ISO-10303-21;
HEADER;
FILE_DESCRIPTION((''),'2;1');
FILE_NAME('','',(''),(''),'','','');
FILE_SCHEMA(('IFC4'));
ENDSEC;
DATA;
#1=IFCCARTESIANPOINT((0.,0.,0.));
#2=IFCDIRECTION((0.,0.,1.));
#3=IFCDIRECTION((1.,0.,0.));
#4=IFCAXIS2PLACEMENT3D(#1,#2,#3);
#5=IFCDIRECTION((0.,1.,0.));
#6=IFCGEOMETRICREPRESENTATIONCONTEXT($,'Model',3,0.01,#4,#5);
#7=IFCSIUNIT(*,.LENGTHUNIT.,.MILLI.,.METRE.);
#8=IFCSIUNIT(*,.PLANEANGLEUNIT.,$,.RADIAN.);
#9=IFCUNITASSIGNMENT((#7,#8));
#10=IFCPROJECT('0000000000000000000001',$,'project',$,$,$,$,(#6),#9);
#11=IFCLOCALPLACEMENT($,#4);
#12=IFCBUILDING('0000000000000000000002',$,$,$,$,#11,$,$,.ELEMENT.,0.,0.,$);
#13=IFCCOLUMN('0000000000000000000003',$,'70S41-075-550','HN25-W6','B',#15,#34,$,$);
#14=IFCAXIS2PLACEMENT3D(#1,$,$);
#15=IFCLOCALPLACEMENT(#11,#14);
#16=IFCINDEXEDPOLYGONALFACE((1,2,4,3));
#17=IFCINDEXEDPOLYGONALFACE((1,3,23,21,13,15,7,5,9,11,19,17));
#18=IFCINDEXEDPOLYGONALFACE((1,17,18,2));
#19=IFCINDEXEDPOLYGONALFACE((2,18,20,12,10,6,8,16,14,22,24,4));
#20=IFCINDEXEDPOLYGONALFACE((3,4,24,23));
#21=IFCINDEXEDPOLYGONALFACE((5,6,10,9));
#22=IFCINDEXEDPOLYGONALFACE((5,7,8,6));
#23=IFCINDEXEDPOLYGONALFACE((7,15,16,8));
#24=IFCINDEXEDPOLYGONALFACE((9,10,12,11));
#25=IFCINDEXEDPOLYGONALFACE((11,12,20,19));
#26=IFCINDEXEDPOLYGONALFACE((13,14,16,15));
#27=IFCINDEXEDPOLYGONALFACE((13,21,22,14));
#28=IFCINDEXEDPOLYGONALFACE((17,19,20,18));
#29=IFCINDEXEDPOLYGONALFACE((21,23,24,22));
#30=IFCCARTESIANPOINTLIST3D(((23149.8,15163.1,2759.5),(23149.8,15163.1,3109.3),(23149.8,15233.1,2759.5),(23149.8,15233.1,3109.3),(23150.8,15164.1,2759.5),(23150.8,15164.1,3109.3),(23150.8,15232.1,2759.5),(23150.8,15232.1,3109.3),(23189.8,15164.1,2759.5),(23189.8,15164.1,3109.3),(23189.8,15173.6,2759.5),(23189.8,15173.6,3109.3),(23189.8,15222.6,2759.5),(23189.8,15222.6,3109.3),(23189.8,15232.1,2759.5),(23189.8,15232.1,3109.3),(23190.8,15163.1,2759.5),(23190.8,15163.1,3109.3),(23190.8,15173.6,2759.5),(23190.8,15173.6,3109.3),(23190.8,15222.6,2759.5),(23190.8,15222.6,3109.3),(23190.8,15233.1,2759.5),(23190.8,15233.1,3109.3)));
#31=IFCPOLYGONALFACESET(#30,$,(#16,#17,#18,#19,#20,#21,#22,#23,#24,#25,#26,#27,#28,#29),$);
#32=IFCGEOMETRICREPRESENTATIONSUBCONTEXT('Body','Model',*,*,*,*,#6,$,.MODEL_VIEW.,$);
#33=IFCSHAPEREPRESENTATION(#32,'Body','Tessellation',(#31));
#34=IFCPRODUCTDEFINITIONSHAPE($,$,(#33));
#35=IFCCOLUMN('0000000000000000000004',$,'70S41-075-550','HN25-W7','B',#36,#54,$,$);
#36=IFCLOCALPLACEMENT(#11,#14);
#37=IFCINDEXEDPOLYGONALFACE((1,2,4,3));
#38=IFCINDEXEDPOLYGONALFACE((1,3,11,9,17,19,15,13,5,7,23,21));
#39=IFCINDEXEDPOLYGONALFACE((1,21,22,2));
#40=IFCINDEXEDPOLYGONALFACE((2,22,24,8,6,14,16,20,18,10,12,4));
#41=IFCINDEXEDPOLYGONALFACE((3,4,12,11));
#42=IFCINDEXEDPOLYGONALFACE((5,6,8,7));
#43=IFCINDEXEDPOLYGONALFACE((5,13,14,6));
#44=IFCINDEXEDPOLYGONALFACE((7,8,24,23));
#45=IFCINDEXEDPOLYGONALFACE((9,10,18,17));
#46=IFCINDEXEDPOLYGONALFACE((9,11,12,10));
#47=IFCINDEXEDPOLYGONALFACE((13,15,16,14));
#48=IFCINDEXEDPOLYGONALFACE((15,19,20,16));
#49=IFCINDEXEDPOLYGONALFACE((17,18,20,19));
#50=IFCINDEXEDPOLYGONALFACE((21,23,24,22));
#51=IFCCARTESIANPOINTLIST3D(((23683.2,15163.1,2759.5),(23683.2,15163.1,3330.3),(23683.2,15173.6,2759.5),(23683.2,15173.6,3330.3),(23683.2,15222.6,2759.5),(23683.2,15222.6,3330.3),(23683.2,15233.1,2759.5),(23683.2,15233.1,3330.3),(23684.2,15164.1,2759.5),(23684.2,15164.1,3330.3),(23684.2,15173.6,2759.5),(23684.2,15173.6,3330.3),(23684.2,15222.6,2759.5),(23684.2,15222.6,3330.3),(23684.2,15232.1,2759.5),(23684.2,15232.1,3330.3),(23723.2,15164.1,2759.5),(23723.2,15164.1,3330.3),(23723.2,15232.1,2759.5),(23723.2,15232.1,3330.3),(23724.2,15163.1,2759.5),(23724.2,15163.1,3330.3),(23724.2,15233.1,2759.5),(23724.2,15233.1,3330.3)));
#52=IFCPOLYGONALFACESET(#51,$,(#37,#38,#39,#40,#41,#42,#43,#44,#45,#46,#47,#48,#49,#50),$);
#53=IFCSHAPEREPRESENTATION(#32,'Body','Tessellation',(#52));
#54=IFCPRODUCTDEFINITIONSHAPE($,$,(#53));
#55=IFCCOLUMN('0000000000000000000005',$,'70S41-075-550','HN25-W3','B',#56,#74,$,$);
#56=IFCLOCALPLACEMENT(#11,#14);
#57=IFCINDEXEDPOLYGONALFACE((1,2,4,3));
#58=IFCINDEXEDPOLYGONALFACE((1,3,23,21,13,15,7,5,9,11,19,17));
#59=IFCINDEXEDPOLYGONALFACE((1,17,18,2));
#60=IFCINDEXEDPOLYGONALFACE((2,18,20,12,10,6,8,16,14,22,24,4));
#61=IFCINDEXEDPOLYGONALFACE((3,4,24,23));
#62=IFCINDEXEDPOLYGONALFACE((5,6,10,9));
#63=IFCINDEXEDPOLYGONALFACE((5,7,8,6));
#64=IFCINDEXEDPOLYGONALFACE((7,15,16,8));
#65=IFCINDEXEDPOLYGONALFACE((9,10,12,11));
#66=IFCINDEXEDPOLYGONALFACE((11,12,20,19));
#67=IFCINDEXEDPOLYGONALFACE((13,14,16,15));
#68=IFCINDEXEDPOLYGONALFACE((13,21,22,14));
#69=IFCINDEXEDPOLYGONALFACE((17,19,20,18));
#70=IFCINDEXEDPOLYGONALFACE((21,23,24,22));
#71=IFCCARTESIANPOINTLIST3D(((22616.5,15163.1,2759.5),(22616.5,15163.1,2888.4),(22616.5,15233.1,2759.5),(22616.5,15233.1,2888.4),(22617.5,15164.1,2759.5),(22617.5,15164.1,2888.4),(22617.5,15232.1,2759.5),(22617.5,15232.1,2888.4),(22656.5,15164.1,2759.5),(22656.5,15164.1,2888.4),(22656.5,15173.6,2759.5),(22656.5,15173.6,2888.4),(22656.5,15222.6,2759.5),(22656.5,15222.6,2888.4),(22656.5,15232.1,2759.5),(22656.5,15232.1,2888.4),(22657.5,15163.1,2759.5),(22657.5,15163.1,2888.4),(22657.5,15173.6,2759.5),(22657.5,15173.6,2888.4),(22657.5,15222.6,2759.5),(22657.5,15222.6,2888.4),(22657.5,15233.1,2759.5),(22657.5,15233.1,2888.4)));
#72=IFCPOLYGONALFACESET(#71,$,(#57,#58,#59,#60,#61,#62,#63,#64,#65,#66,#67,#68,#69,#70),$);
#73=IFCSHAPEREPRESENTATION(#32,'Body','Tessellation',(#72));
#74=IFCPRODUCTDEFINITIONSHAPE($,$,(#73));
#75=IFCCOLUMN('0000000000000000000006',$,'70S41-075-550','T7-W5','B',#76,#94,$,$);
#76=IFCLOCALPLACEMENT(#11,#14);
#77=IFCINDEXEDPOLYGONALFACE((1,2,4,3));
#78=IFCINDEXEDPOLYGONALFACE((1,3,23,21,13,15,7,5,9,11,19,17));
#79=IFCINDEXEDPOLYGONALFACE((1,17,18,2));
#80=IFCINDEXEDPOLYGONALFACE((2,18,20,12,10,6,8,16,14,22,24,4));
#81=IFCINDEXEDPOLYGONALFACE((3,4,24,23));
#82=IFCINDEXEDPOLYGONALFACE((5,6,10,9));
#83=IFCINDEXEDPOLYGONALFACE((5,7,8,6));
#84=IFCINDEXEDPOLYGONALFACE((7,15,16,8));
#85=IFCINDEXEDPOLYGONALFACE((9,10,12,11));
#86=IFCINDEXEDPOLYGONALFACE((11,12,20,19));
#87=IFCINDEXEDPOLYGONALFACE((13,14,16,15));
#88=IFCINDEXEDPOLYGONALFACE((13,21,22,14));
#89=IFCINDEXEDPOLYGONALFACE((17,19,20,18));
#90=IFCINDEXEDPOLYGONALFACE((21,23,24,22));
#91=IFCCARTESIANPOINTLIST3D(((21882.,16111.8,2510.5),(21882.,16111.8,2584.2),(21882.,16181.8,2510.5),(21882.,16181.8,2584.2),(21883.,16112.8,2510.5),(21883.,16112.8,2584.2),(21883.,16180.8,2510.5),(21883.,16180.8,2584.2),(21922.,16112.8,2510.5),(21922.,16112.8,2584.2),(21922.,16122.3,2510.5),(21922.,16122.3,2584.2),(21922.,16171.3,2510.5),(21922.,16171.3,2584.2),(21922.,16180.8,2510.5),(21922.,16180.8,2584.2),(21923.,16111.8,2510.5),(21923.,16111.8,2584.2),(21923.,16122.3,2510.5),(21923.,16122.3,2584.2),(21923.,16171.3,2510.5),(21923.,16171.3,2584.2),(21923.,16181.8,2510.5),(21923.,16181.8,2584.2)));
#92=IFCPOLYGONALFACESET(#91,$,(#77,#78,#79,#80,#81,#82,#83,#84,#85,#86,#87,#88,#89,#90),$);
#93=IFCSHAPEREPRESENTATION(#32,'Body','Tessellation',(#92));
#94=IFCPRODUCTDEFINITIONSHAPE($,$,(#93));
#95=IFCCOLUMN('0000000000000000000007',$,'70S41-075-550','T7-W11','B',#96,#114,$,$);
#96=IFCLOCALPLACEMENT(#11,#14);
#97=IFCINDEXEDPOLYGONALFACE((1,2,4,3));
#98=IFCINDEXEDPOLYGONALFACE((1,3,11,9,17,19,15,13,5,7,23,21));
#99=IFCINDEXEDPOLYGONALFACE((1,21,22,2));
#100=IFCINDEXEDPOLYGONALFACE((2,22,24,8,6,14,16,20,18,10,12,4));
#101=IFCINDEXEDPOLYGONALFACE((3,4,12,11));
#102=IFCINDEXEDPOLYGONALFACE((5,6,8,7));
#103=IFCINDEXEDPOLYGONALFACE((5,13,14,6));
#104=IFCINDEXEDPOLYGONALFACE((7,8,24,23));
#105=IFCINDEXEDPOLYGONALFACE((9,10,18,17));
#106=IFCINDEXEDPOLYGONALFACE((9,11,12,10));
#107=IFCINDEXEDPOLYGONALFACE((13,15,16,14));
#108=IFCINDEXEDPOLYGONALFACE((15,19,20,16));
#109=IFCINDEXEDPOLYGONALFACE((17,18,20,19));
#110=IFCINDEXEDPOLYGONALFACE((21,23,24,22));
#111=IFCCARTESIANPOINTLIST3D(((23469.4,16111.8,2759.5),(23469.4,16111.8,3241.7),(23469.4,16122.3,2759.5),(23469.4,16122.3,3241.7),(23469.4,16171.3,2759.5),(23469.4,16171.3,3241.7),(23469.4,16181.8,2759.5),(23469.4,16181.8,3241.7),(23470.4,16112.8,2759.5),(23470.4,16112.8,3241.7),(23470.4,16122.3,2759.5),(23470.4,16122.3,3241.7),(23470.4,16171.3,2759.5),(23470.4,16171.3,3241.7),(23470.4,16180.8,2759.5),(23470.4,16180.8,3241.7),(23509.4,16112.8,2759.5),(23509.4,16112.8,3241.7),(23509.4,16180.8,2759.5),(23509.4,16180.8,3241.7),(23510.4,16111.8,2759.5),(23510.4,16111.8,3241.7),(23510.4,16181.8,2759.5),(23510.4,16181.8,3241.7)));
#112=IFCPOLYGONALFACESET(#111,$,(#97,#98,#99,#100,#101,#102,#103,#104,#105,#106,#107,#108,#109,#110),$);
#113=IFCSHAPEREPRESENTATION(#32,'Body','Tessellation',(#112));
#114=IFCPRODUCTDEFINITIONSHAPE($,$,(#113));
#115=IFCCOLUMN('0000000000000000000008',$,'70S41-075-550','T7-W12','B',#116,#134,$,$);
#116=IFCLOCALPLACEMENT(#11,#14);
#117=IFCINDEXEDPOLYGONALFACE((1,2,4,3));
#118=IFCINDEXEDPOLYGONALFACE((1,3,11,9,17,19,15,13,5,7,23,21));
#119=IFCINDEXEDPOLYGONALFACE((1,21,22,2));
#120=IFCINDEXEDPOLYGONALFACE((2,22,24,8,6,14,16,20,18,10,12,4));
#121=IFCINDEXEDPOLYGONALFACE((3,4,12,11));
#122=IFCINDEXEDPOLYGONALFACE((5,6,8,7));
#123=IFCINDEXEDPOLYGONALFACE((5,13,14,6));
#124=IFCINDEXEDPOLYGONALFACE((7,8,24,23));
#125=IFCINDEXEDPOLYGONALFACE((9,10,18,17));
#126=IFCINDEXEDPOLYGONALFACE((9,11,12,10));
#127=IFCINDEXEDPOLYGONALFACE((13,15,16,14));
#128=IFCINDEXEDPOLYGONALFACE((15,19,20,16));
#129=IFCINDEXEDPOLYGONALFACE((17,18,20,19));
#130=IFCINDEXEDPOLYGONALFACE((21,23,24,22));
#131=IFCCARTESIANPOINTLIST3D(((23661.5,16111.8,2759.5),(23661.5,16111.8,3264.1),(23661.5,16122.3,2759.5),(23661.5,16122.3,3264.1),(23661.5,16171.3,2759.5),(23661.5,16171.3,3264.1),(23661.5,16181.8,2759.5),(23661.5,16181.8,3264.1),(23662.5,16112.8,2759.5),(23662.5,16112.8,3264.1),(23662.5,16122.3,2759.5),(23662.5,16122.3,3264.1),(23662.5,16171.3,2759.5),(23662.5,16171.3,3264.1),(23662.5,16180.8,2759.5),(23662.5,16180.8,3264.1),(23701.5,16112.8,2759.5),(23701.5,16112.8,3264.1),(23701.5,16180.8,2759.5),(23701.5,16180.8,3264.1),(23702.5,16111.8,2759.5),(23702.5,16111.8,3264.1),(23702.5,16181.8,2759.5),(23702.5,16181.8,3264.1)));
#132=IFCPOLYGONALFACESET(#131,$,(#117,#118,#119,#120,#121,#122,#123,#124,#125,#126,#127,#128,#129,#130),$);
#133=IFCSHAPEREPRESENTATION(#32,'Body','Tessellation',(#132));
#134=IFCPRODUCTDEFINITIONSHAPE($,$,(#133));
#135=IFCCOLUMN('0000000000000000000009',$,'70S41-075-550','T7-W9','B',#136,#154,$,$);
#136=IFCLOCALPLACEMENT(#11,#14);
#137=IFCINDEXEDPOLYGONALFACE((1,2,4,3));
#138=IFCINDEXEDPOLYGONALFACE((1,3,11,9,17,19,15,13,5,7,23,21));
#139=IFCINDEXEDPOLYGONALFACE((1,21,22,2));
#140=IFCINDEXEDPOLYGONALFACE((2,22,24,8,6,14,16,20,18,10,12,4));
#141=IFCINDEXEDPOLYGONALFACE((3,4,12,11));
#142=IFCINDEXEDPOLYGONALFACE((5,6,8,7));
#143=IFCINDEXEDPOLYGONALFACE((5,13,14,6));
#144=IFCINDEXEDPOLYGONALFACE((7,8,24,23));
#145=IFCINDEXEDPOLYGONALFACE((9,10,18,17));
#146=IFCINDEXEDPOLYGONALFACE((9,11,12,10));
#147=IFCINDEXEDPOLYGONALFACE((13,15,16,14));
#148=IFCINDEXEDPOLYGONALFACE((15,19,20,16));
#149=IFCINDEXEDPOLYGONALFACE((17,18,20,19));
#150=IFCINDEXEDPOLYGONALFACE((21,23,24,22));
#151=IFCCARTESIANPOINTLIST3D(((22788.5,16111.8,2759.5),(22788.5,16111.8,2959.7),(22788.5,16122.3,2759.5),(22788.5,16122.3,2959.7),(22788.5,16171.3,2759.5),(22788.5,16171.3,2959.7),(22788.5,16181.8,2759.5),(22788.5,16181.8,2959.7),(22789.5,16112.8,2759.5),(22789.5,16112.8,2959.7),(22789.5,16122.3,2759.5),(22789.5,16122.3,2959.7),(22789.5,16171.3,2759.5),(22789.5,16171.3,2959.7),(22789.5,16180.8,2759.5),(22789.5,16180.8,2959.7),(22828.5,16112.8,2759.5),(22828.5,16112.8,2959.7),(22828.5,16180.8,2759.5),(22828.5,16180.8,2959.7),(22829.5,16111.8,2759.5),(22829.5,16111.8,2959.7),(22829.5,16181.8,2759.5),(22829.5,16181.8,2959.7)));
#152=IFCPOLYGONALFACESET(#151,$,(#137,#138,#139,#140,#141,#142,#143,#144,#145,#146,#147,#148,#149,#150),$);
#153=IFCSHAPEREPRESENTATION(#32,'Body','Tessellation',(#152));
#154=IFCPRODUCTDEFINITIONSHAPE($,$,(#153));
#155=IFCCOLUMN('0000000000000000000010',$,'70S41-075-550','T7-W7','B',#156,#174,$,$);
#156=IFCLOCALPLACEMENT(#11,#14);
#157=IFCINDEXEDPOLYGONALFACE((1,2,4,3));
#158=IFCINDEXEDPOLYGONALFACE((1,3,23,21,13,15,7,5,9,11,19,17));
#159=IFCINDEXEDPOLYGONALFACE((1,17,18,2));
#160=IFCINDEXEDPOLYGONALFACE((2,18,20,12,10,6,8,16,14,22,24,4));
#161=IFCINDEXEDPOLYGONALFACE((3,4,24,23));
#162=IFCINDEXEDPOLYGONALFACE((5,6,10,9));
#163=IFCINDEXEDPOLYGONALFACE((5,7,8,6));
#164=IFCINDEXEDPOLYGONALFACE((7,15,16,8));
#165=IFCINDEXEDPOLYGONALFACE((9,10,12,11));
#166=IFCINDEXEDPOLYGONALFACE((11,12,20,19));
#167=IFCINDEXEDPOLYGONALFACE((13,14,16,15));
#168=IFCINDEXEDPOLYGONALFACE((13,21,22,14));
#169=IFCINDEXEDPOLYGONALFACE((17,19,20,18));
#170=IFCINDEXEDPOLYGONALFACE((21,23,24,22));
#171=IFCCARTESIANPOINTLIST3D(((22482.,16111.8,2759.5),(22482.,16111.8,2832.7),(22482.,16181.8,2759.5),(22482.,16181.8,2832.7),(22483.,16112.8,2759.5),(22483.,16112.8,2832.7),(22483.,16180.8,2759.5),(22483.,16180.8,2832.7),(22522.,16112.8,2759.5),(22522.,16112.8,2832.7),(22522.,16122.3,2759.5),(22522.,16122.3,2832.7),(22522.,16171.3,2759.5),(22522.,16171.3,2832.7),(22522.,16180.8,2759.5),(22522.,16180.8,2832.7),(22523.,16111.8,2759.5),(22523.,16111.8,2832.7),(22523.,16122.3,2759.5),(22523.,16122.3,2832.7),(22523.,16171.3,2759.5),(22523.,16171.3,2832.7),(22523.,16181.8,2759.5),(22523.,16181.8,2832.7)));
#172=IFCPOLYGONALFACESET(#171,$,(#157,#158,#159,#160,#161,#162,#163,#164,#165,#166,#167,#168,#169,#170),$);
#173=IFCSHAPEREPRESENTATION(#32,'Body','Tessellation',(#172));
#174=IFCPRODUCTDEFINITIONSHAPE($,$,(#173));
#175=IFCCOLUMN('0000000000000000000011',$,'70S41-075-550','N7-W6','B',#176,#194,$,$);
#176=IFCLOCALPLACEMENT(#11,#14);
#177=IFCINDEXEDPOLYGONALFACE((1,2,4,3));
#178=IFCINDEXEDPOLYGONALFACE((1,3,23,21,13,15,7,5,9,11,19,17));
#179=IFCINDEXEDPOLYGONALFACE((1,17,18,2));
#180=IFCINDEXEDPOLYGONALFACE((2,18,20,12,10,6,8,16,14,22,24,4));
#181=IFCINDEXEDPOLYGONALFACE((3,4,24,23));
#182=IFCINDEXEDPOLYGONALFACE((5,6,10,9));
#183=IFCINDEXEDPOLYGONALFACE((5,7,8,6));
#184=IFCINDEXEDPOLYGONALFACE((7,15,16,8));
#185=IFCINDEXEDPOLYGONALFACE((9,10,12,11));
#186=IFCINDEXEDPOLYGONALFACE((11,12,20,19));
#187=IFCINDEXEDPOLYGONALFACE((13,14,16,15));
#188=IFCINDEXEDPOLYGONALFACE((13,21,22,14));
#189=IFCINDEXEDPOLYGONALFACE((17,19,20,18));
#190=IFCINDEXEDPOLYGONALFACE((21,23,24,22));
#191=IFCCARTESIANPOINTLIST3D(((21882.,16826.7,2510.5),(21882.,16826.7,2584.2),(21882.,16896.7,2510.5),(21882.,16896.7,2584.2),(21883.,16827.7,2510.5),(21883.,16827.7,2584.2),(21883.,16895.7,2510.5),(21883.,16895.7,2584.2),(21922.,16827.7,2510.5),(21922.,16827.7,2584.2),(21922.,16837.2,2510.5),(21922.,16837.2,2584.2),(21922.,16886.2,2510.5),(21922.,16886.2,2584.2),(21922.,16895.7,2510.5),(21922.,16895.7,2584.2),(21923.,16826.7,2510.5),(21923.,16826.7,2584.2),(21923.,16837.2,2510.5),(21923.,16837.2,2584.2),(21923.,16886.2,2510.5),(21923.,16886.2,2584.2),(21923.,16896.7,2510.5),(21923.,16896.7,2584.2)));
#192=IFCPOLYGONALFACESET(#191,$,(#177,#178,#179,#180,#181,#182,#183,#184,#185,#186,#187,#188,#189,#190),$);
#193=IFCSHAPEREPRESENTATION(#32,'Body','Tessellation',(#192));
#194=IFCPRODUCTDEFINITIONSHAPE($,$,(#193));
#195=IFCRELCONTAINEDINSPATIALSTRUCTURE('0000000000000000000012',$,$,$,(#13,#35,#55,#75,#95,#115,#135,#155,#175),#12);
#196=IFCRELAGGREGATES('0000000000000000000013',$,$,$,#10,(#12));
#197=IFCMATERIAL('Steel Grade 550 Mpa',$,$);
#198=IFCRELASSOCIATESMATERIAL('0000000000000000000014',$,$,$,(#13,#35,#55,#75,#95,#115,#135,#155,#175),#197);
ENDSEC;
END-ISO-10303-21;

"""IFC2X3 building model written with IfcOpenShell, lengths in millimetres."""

from ifc_helpers import new_model, si_unit, direction, frame, origin, origin_with_axes, origin_2d_with_axis, place, context, subcontext, project, spatial, c_section, extrude, source, transform, mapped, material, element, save


model = new_model("IFC2X3")

# Units and contexts
model_context = context("Model", 3, precision=0.01, world=origin_with_axes(), true_north=direction((0.0, 1.0, 0.0)))
body_context = subcontext(model_context, "Body", "Model", "MODEL_VIEW")
ifc_project = project(units=[si_unit("LENGTHUNIT", "METRE", prefix="MILLI"), si_unit("PLANEANGLEUNIT", "RADIAN")], contexts=[model_context])

# Building
building_placement = place(None, origin_with_axes())
building = spatial("IfcBuilding", under=ifc_project, at=building_placement, CompositionType="ELEMENT", ElevationOfRefHeight=0.0, ElevationOfTerrain=0.0)

# Columns
ifc_material = material(Name="Steel Grade 550 Mpa")
shared_shape_1 = source(origin(), body_context, "Body", "SweptSolid", [
    extrude(c_section(Depth=70.0, Width=41.0, WallThickness=1.0, Girth=10.5, at=origin_2d_with_axis()), origin_with_axes(), (0.0, 0.0, 1.0), 349.8),
])
column_1_placement = place(None, frame((23170.3, 15198.1, 3109.3), z_axis=(0.0, 0.0, -1.0), x_axis=(1.0, 0.0, 0.0)))
element("IfcColumn", 1, at=column_1_placement, inside=building, material=ifc_material, Name="70S41-075-550", Description="HN25-W6", ObjectType="B", context=body_context, shape_type="MappedRepresentation", body=[
    mapped(shared_shape_1, transform((0.0, 0.0, 0.0), scale=1.0)),
])
shared_shape_2 = source(origin(), body_context, "Body", "SweptSolid", [
    extrude(c_section(Depth=70.0, Width=41.0, WallThickness=1.0, Girth=10.5, at=origin_2d_with_axis()), origin_with_axes(), (0.0, 0.0, 1.0), 570.8),
])
column_2_placement = place(None, frame((23703.7, 15198.1, 2759.5), z_axis=(0.0, 0.0, 1.0), x_axis=(-1.0, 0.0, 0.0)))
element("IfcColumn", 2, at=column_2_placement, inside=building, material=ifc_material, Name="70S41-075-550", Description="HN25-W7", ObjectType="B", context=body_context, shape_type="MappedRepresentation", body=[
    mapped(shared_shape_2, transform((0.0, 0.0, 0.0), scale=1.0)),
])
shared_shape_3 = source(origin(), body_context, "Body", "SweptSolid", [
    extrude(c_section(Depth=70.0, Width=41.0, WallThickness=1.0, Girth=10.5, at=origin_2d_with_axis()), origin_with_axes(), (0.0, 0.0, 1.0), 128.9),
])
column_3_placement = place(None, frame((22637.0, 15198.1, 2888.4), z_axis=(0.0, 0.0, -1.0), x_axis=(1.0, 0.0, 0.0)))
element("IfcColumn", 3, at=column_3_placement, inside=building, material=ifc_material, Name="70S41-075-550", Description="HN25-W3", ObjectType="B", context=body_context, shape_type="MappedRepresentation", body=[
    mapped(shared_shape_3, transform((0.0, 0.0, 0.0), scale=1.0)),
])
shared_shape_4 = source(origin(), body_context, "Body", "SweptSolid", [
    extrude(c_section(Depth=70.0, Width=41.0, WallThickness=1.0, Girth=10.5, at=origin_2d_with_axis()), origin_with_axes(), (0.0, 0.0, 1.0), 73.7),
])
column_4_placement = place(None, frame((21902.5, 16146.8, 2584.2), z_axis=(0.0, 0.0, -1.0), x_axis=(1.0, 0.0, 0.0)))
element("IfcColumn", 4, at=column_4_placement, inside=building, material=ifc_material, Name="70S41-075-550", Description="T7-W5", ObjectType="B", context=body_context, shape_type="MappedRepresentation", body=[
    mapped(shared_shape_4, transform((0.0, 0.0, 0.0), scale=1.0)),
])
shared_shape_5 = source(origin(), body_context, "Body", "SweptSolid", [
    extrude(c_section(Depth=70.0, Width=41.0, WallThickness=1.0, Girth=10.5, at=origin_2d_with_axis()), origin_with_axes(), (0.0, 0.0, 1.0), 482.2),
])
column_5_placement = place(None, frame((23489.9, 16146.8, 2759.5), z_axis=(0.0, 0.0, 1.0), x_axis=(-1.0, 0.0, 0.0)))
element("IfcColumn", 5, at=column_5_placement, inside=building, material=ifc_material, Name="70S41-075-550", Description="T7-W11", ObjectType="B", context=body_context, shape_type="MappedRepresentation", body=[
    mapped(shared_shape_5, transform((0.0, 0.0, 0.0), scale=1.0)),
])
shared_shape_6 = source(origin(), body_context, "Body", "SweptSolid", [
    extrude(c_section(Depth=70.0, Width=41.0, WallThickness=1.0, Girth=10.5, at=origin_2d_with_axis()), origin_with_axes(), (0.0, 0.0, 1.0), 504.6),
])
column_6_placement = place(None, frame((23682.0, 16146.8, 2759.5), z_axis=(0.0, 0.0, 1.0), x_axis=(-1.0, 0.0, 0.0)))
element("IfcColumn", 6, at=column_6_placement, inside=building, material=ifc_material, Name="70S41-075-550", Description="T7-W12", ObjectType="B", context=body_context, shape_type="MappedRepresentation", body=[
    mapped(shared_shape_6, transform((0.0, 0.0, 0.0), scale=1.0)),
])
shared_shape_7 = source(origin(), body_context, "Body", "SweptSolid", [
    extrude(c_section(Depth=70.0, Width=41.0, WallThickness=1.0, Girth=10.5, at=origin_2d_with_axis()), origin_with_axes(), (0.0, 0.0, 1.0), 200.2),
])
column_7_placement = place(None, frame((22809.0, 16146.8, 2759.5), z_axis=(0.0, 0.0, 1.0), x_axis=(-1.0, 0.0, 0.0)))
element("IfcColumn", 7, at=column_7_placement, inside=building, material=ifc_material, Name="70S41-075-550", Description="T7-W9", ObjectType="B", context=body_context, shape_type="MappedRepresentation", body=[
    mapped(shared_shape_7, transform((0.0, 0.0, 0.0), scale=1.0)),
])
shared_shape_8 = source(origin(), body_context, "Body", "SweptSolid", [
    extrude(c_section(Depth=70.0, Width=41.0, WallThickness=1.0, Girth=10.5, at=origin_2d_with_axis()), origin_with_axes(), (0.0, 0.0, 1.0), 73.2),
])
column_8_placement = place(None, frame((22502.5, 16146.8, 2832.7), z_axis=(0.0, 0.0, -1.0), x_axis=(1.0, 0.0, 0.0)))
element("IfcColumn", 8, at=column_8_placement, inside=building, material=ifc_material, Name="70S41-075-550", Description="T7-W7", ObjectType="B", context=body_context, shape_type="MappedRepresentation", body=[
    mapped(shared_shape_8, transform((0.0, 0.0, 0.0), scale=1.0)),
])
shared_shape_9 = source(origin(), body_context, "Body", "SweptSolid", [
    extrude(c_section(Depth=70.0, Width=41.0, WallThickness=1.0, Girth=10.5, at=origin_2d_with_axis()), origin_with_axes(), (0.0, 0.0, 1.0), 73.7),
])
column_9_placement = place(None, frame((21902.5, 16861.7, 2584.2), z_axis=(0.0, 0.0, -1.0), x_axis=(1.0, 0.0, 0.0)))
element("IfcColumn", 9, at=column_9_placement, inside=building, material=ifc_material, Name="70S41-075-550", Description="N7-W6", ObjectType="B", context=body_context, shape_type="MappedRepresentation", body=[
    mapped(shared_shape_9, transform((0.0, 0.0, 0.0), scale=1.0)),
])

save(model, "model.ifc")
